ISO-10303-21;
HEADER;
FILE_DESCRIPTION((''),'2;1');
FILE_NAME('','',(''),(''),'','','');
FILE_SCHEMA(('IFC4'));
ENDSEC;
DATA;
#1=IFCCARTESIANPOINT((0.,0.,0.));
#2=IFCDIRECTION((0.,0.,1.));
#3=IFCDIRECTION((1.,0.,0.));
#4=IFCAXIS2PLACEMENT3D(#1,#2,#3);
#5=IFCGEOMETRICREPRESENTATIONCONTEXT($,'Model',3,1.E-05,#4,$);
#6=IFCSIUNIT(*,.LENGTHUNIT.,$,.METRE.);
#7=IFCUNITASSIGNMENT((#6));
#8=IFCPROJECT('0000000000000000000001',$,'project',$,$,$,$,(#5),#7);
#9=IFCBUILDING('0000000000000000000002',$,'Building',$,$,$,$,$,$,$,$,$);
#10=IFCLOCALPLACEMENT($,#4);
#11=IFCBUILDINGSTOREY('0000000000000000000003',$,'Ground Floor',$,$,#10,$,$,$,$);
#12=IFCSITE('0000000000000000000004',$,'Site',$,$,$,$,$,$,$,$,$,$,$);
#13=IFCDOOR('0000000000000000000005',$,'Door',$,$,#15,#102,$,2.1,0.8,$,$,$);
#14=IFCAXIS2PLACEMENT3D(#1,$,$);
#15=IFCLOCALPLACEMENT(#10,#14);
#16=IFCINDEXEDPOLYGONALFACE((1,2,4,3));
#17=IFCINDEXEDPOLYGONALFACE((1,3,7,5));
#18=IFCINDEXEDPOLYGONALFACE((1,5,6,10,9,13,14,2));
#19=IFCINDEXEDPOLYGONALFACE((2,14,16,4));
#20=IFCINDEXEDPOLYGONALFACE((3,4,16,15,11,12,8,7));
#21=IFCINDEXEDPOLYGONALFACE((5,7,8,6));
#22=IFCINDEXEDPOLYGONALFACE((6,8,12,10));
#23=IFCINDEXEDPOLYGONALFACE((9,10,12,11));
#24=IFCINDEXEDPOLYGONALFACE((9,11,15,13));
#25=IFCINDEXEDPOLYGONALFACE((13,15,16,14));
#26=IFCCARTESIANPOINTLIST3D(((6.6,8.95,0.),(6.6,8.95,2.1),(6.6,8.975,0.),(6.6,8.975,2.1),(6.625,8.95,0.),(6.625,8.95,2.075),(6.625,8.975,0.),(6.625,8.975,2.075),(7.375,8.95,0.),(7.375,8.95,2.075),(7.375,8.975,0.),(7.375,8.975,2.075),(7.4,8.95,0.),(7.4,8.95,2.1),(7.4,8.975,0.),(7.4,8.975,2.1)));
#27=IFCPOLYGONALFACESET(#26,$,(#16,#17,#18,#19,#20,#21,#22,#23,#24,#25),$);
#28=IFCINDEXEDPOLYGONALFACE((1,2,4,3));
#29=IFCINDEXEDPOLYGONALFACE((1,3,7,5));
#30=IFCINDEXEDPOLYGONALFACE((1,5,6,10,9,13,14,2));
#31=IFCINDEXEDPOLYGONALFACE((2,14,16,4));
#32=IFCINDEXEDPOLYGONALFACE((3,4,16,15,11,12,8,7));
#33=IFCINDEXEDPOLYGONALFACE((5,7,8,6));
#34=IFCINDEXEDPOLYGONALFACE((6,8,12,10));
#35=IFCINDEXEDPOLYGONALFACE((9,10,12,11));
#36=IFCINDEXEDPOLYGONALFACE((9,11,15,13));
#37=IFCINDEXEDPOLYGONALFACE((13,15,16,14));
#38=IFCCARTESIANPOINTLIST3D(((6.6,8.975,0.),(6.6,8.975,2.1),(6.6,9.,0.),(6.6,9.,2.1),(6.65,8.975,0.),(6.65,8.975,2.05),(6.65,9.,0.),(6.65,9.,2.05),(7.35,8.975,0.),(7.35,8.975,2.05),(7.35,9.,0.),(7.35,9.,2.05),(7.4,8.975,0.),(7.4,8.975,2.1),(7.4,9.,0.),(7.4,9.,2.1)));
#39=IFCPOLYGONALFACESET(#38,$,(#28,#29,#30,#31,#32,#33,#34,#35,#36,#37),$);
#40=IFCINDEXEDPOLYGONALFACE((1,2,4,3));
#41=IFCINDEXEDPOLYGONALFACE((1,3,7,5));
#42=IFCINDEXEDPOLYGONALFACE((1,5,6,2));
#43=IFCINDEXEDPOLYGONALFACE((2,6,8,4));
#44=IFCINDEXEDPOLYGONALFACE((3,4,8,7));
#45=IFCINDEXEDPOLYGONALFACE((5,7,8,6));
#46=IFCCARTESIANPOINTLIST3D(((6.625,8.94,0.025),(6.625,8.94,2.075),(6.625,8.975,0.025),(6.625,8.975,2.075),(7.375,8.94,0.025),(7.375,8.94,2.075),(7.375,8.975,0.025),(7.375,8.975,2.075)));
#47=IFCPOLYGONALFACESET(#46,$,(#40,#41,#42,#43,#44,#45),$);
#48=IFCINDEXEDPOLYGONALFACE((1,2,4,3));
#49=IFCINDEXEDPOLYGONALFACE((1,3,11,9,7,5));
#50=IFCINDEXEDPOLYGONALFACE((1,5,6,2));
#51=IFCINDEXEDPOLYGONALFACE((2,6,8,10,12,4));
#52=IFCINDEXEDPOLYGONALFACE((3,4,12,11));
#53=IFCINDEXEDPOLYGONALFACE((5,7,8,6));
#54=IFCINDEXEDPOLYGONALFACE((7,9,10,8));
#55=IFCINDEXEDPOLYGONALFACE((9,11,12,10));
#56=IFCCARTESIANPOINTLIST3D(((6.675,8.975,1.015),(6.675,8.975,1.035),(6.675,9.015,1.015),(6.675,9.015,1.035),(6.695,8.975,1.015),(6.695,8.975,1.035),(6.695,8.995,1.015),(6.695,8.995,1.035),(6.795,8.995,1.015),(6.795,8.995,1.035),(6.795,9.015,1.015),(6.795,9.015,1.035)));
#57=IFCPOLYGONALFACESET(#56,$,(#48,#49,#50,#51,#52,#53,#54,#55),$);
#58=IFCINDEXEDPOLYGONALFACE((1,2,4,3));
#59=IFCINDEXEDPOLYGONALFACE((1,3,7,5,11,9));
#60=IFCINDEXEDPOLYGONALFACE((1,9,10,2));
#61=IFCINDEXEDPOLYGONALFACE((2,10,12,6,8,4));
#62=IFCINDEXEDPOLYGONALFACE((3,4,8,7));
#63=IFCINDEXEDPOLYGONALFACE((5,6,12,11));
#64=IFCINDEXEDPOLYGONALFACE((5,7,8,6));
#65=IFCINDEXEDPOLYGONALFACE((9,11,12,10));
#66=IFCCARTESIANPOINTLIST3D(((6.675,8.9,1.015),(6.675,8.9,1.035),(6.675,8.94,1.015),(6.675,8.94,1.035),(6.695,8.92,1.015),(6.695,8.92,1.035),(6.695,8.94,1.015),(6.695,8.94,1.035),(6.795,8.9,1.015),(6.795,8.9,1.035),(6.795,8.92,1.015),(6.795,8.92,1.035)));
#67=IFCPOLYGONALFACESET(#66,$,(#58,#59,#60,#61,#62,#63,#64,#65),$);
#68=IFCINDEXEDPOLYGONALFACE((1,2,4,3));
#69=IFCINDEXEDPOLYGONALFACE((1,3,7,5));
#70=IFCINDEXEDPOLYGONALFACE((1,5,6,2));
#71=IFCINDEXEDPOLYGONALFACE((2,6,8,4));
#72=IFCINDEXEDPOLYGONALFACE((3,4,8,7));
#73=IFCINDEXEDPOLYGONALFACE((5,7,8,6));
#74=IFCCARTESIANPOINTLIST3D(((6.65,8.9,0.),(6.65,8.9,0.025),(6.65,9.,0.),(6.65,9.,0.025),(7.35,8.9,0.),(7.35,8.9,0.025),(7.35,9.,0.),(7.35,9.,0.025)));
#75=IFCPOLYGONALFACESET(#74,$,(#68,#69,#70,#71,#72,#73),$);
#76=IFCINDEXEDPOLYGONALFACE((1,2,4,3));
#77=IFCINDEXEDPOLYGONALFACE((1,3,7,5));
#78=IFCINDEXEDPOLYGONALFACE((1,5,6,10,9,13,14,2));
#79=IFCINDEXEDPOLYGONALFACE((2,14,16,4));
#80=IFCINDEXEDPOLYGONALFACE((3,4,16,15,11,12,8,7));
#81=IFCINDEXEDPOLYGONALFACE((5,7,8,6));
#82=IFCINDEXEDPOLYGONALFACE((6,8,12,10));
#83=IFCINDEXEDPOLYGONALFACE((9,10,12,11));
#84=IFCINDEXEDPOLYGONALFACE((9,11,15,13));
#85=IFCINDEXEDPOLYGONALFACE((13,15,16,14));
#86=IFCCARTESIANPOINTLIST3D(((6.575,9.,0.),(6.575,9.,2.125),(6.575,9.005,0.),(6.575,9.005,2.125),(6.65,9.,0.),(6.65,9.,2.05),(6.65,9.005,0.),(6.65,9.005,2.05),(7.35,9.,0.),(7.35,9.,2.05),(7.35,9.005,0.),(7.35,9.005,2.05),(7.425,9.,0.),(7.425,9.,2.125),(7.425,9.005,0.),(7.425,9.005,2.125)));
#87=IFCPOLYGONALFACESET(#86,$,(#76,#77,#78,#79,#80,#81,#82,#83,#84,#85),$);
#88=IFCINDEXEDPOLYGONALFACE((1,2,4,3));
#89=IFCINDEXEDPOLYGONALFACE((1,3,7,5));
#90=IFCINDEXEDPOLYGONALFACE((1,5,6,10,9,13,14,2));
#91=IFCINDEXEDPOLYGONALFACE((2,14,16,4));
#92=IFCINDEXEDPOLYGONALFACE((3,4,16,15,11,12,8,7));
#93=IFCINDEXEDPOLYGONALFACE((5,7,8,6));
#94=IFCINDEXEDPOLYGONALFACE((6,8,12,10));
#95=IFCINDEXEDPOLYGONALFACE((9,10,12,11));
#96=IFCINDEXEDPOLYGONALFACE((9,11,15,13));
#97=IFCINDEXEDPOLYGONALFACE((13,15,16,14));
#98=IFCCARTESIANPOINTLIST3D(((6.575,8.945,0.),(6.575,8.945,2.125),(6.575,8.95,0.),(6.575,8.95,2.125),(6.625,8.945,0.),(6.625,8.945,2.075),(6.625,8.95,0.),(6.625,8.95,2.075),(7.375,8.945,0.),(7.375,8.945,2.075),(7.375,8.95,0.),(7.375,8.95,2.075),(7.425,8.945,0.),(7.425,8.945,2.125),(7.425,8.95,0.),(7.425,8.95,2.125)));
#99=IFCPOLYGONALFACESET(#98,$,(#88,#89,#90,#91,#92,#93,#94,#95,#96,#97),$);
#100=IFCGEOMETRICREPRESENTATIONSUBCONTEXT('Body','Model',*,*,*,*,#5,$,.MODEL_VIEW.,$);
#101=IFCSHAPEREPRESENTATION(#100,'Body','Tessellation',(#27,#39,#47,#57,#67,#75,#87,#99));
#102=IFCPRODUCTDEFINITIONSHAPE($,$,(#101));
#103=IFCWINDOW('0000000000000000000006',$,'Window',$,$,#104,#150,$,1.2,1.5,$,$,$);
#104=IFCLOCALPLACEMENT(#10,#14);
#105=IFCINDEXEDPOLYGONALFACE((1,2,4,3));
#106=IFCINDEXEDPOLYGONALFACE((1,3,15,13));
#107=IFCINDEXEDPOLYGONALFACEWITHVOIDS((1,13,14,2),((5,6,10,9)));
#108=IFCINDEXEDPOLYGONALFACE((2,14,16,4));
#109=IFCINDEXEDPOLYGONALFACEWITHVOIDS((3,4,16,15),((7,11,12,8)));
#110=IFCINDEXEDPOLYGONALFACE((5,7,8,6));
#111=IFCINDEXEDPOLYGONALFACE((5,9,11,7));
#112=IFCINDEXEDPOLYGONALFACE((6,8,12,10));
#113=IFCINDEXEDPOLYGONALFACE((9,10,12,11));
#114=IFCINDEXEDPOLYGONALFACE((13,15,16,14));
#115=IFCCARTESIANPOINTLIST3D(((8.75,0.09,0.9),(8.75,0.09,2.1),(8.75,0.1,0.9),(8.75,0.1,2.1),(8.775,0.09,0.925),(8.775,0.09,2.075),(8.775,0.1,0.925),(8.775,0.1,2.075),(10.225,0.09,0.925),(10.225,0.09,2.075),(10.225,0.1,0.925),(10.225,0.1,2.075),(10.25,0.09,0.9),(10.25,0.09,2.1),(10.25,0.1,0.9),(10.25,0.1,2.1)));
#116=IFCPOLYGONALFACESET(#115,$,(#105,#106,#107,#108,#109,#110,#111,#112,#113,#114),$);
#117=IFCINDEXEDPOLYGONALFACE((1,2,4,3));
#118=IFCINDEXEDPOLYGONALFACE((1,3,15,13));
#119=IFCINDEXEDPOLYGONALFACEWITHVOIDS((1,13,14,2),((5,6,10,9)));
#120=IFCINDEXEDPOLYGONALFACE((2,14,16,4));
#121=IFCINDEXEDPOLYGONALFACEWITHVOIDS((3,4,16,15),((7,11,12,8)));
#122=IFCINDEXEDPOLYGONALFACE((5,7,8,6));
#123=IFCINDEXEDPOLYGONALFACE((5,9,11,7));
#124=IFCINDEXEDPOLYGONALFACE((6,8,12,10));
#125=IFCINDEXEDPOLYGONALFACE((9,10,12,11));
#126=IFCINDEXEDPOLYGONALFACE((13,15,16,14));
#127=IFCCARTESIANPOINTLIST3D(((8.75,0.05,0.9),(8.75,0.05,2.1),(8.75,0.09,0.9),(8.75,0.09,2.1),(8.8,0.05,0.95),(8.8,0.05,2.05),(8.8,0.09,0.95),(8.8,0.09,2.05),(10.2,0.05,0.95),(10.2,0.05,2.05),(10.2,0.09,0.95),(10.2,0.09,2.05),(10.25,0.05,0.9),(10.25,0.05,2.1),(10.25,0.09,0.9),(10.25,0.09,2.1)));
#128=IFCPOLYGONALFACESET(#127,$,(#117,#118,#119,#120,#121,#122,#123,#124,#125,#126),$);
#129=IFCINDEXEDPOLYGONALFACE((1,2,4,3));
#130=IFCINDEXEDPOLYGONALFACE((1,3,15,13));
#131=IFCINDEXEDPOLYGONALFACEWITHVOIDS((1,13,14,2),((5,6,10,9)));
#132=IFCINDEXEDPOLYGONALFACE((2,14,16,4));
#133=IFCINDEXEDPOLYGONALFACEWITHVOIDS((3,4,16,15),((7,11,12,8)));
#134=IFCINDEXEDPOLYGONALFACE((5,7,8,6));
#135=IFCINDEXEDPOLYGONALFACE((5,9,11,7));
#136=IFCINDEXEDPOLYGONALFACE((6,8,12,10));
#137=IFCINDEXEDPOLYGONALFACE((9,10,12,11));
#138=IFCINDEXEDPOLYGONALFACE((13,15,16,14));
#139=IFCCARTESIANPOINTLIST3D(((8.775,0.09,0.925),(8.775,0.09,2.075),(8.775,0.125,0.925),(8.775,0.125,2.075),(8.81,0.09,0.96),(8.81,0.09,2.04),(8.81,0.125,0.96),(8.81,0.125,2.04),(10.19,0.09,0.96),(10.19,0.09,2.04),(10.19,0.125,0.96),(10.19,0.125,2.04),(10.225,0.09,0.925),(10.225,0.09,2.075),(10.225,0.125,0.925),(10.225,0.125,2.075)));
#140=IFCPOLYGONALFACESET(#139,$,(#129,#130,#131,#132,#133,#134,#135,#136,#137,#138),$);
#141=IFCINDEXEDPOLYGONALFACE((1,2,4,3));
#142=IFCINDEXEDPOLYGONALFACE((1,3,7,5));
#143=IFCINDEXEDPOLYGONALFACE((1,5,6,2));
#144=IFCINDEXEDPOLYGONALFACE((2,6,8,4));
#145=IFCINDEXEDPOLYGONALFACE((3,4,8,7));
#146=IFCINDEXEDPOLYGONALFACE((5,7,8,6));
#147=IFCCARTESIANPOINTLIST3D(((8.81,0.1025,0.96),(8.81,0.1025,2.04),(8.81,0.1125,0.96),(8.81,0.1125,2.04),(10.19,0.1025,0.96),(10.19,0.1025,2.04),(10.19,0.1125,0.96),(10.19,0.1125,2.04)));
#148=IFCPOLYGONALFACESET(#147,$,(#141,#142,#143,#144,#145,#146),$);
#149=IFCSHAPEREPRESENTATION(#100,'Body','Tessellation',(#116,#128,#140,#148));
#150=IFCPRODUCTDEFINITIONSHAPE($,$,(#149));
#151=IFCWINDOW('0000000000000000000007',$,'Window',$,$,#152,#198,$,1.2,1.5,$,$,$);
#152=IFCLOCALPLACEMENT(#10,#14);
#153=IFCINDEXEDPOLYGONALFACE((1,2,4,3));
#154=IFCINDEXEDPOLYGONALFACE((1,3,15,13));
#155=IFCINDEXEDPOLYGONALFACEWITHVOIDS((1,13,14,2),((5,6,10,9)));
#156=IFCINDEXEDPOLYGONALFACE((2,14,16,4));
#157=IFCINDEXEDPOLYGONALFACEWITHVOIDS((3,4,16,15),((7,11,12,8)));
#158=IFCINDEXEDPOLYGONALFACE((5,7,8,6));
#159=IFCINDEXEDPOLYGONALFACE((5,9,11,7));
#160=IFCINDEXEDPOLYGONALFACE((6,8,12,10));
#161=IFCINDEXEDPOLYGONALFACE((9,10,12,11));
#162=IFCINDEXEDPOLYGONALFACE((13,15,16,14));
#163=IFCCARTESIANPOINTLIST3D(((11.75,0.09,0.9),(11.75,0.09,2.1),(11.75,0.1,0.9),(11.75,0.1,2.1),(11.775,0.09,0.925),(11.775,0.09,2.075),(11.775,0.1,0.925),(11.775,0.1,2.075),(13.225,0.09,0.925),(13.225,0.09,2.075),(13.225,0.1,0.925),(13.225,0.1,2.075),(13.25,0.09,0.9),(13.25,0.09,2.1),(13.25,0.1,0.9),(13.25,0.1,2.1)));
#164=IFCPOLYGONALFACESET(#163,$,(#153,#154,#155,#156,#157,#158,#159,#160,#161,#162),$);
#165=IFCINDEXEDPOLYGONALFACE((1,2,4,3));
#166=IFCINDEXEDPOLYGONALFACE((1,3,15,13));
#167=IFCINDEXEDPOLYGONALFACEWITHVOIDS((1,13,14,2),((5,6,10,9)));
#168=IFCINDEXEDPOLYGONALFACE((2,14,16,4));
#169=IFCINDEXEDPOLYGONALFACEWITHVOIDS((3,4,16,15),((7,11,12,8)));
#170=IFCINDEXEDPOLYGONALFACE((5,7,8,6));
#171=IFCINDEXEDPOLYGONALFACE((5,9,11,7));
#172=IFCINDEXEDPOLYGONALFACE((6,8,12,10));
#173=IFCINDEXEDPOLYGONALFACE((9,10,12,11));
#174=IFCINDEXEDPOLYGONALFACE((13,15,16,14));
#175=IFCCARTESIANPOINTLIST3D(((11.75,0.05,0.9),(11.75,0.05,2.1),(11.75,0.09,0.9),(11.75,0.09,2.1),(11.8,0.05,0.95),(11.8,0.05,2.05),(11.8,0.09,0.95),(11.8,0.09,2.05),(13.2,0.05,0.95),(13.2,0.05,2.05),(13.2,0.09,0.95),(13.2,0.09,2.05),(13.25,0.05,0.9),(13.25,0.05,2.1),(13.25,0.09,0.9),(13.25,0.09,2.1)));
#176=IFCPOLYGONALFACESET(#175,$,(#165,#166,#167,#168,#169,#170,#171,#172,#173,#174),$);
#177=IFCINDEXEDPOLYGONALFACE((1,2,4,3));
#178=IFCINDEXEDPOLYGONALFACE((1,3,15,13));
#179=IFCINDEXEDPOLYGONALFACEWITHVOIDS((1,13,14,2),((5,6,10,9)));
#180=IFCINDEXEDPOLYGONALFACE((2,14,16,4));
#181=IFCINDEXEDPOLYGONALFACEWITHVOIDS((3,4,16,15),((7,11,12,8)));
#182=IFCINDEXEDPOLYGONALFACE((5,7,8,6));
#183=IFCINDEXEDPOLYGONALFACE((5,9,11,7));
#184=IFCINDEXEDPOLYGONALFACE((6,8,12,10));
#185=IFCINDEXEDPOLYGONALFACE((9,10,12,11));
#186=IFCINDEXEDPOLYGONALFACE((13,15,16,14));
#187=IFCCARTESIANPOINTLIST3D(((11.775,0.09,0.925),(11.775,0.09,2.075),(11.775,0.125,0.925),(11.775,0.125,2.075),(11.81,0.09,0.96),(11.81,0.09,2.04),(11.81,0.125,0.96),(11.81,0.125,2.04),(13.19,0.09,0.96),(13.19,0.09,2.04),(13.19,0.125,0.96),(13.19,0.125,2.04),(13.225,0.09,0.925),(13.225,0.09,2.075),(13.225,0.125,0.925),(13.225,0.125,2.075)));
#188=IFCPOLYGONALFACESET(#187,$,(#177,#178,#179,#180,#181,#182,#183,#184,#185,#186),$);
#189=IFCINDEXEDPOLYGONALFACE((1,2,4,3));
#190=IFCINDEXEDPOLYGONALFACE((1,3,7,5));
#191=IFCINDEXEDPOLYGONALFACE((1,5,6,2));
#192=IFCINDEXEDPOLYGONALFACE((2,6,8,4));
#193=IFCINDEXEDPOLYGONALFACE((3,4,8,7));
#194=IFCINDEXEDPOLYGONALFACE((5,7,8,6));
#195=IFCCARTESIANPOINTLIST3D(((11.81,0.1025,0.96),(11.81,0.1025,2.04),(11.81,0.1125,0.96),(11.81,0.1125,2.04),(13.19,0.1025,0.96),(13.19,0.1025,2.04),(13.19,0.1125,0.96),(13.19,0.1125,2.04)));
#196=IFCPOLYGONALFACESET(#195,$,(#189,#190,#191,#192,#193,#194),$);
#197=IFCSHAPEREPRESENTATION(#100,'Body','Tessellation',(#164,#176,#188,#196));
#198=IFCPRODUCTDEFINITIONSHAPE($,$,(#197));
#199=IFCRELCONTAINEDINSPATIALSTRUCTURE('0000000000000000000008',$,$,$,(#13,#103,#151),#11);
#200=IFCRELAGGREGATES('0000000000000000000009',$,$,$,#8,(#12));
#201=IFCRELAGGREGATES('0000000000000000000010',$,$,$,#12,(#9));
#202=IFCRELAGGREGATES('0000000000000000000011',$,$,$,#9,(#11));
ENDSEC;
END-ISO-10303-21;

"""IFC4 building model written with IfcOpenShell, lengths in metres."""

from ifc_helpers import new_model, si_unit, frame, origin_with_axes, place, context, subcontext, project, spatial, line, indexed_curve, outline, extrude, element, save


model = new_model("IFC4")

# Units and contexts
model_context = context("Model", 3, precision=1e-05, world=origin_with_axes())
body_context = subcontext(model_context, "Body", "Model", "MODEL_VIEW")
ifc_project = project(units=[si_unit("LENGTHUNIT", "METRE")], contexts=[model_context])

# Site, building, storey
site = spatial("IfcSite", under=ifc_project, Name="Site")
building = spatial("IfcBuilding", under=site, Name="Building")
storey_placement = place(None, origin_with_axes())
storey = spatial("IfcBuildingStorey", under=building, at=storey_placement, Name="Ground Floor")

# Door
door_1_placement = place(storey_placement, frame((7.4, 9.0, 0.0), z_axis=(0.0, 0.0, 1.0), x_axis=(-1.0, 0.0, 0.0)))
element("IfcDoor", 1, at=door_1_placement, inside=storey, Name="Door", OverallHeight=2.1, OverallWidth=0.8, context=body_context, shape_type="SweptSolid", body=[
    extrude(outline(indexed_curve([(0.0, 0.0), (0.0, 2.1), (0.8, 2.1), (0.8, 0.0), (0.775, 0.0), (0.775, 2.075), (0.025, 2.075), (0.025, 0.0)], segments=[line(1, 2, 3, 4, 5, 6, 7, 8, 1)])), frame((0.0, 0.025, 0.0), z_axis=(0.0, -1.0, 0.0), x_axis=(1.0, 0.0, 0.0)), (0.0, 0.0, -1.0), 0.025),
    extrude(outline(indexed_curve([(0.0, 0.0), (0.0, 2.1), (0.8, 2.1), (0.8, 0.0), (0.75, 0.0), (0.75, 2.05), (0.05, 2.05), (0.05, 0.0)], segments=[line(1, 2, 3, 4, 5, 6, 7, 8, 1)])), frame((0.0, 0.0, 0.0), z_axis=(0.0, -1.0, 0.0), x_axis=(1.0, 0.0, 0.0)), (0.0, 0.0, -1.0), 0.025),
    extrude(outline(indexed_curve([(0.0, 0.0), (0.75, 0.0), (0.75, 0.035), (0.0, 0.035)], segments=[line(1, 2, 3, 4, 1)])), frame((0.025, 0.025, 0.025), z_axis=(0.0, 0.0, 1.0), x_axis=(1.0, 0.0, 0.0)), (0.0, 0.0, 1.0), 2.05),
    extrude(outline(indexed_curve([(0.0, 0.0), (0.0, -0.04), (-0.12, -0.04), (-0.12, -0.02), (-0.02, -0.02), (-0.02, 0.0)], segments=[line(1, 2, 3, 4, 5, 6, 1)])), frame((0.725, 0.025, 1.015), z_axis=(0.0, 0.0, 1.0), x_axis=(1.0, 0.0, 0.0)), (0.0, 0.0, 1.0), 0.02),
    extrude(outline(indexed_curve([(0.0, 0.0), (0.0, 0.04), (-0.12, 0.04), (-0.12, 0.02), (-0.02, 0.02), (-0.02, 0.0)], segments=[line(1, 2, 3, 4, 5, 6, 1)])), frame((0.725, 0.06, 1.015), z_axis=(0.0, 0.0, 1.0), x_axis=(1.0, 0.0, 0.0)), (0.0, 0.0, 1.0), 0.02),
    extrude(outline(indexed_curve([(0.0, 0.0), (0.7, 0.0), (0.7, 0.1), (0.0, 0.1)], segments=[line(1, 2, 3, 4, 1)])), frame((0.05, 0.0, 0.0), z_axis=(0.0, 0.0, 1.0), x_axis=(1.0, 0.0, 0.0)), (0.0, 0.0, 1.0), 0.025),
    extrude(outline(indexed_curve([(0.0, 0.0), (0.0, 2.125), (0.85, 2.125), (0.85, 0.0), (0.775, 0.0), (0.775, 2.05), (0.075, 2.05), (0.075, 0.0)], segments=[line(1, 2, 3, 4, 5, 6, 7, 8, 1)])), frame((-0.025, -0.005, 0.0), z_axis=(0.0, -1.0, 0.0), x_axis=(1.0, 0.0, 0.0)), (0.0, 0.0, -1.0), 0.005),
    extrude(outline(indexed_curve([(0.0, 0.0), (0.0, 2.125), (0.85, 2.125), (0.85, 0.0), (0.8, 0.0), (0.8, 2.075), (0.05, 2.075), (0.05, 0.0)], segments=[line(1, 2, 3, 4, 5, 6, 7, 8, 1)])), frame((-0.025, 0.05, 0.0), z_axis=(0.0, -1.0, 0.0), x_axis=(1.0, 0.0, 0.0)), (0.0, 0.0, -1.0), 0.005),
])

# Windows
for number, where, z_axis, x_axis, name in (
    (2, (8.75, 0.0, 0.9), (0.0, 0.0, 1.0), (1.0, 0.0, 0.0), "Window"),
    (3, (11.75, 0.0, 0.9), (0.0, 0.0, 1.0), (1.0, 0.0, 0.0), "Window"),
):
    element("IfcWindow", number, at=place(storey_placement, frame(where, z_axis=z_axis, x_axis=x_axis)), inside=storey, Name=name, OverallHeight=1.2, OverallWidth=1.5, context=body_context, shape_type="SweptSolid", body=[
        extrude(outline(indexed_curve([(0.0, 0.0), (1.5, 0.0), (1.5, 1.2), (0.0, 1.2)], segments=[line(1, 2, 3, 4, 1)]), holes=[indexed_curve([(0.025, 0.025), (1.475, 0.025), (1.475, 1.175), (0.025, 1.175)], segments=[line(1, 2, 3, 4, 1)])]), frame((0.0, 0.09, 0.0), z_axis=(0.0, -1.0, 0.0), x_axis=(1.0, 0.0, 0.0)), (0.0, 0.0, -1.0), 0.01),
        extrude(outline(indexed_curve([(0.0, 0.0), (1.5, 0.0), (1.5, 1.2), (0.0, 1.2)], segments=[line(1, 2, 3, 4, 1)]), holes=[indexed_curve([(0.05, 0.05), (1.45, 0.05), (1.45, 1.15), (0.05, 1.15)], segments=[line(1, 2, 3, 4, 1)])]), frame((0.0, 0.05, 0.0), z_axis=(0.0, -1.0, 0.0), x_axis=(1.0, 0.0, 0.0)), (0.0, 0.0, -1.0), 0.04),
        extrude(outline(indexed_curve([(0.0, 0.0), (1.45, 0.0), (1.45, 1.15), (0.0, 1.15)], segments=[line(1, 2, 3, 4, 1)]), holes=[indexed_curve([(0.035, 0.035), (1.415, 0.035), (1.415, 1.115), (0.035, 1.115)], segments=[line(1, 2, 3, 4, 1)])]), frame((0.025, 0.09, 0.025), z_axis=(0.0, -1.0, 0.0), x_axis=(1.0, 0.0, 0.0)), (0.0, 0.0, -1.0), 0.035),
        extrude(outline(indexed_curve([(0.035, 0.035), (1.415, 0.035), (1.415, 1.115), (0.035, 1.115)], segments=[line(1, 2, 3, 4, 1)])), frame((0.025, 0.1025, 0.025), z_axis=(0.0, -1.0, 0.0), x_axis=(1.0, 0.0, 0.0)), (0.0, 0.0, -1.0), 0.01),
    ])

save(model, "model.ifc")
